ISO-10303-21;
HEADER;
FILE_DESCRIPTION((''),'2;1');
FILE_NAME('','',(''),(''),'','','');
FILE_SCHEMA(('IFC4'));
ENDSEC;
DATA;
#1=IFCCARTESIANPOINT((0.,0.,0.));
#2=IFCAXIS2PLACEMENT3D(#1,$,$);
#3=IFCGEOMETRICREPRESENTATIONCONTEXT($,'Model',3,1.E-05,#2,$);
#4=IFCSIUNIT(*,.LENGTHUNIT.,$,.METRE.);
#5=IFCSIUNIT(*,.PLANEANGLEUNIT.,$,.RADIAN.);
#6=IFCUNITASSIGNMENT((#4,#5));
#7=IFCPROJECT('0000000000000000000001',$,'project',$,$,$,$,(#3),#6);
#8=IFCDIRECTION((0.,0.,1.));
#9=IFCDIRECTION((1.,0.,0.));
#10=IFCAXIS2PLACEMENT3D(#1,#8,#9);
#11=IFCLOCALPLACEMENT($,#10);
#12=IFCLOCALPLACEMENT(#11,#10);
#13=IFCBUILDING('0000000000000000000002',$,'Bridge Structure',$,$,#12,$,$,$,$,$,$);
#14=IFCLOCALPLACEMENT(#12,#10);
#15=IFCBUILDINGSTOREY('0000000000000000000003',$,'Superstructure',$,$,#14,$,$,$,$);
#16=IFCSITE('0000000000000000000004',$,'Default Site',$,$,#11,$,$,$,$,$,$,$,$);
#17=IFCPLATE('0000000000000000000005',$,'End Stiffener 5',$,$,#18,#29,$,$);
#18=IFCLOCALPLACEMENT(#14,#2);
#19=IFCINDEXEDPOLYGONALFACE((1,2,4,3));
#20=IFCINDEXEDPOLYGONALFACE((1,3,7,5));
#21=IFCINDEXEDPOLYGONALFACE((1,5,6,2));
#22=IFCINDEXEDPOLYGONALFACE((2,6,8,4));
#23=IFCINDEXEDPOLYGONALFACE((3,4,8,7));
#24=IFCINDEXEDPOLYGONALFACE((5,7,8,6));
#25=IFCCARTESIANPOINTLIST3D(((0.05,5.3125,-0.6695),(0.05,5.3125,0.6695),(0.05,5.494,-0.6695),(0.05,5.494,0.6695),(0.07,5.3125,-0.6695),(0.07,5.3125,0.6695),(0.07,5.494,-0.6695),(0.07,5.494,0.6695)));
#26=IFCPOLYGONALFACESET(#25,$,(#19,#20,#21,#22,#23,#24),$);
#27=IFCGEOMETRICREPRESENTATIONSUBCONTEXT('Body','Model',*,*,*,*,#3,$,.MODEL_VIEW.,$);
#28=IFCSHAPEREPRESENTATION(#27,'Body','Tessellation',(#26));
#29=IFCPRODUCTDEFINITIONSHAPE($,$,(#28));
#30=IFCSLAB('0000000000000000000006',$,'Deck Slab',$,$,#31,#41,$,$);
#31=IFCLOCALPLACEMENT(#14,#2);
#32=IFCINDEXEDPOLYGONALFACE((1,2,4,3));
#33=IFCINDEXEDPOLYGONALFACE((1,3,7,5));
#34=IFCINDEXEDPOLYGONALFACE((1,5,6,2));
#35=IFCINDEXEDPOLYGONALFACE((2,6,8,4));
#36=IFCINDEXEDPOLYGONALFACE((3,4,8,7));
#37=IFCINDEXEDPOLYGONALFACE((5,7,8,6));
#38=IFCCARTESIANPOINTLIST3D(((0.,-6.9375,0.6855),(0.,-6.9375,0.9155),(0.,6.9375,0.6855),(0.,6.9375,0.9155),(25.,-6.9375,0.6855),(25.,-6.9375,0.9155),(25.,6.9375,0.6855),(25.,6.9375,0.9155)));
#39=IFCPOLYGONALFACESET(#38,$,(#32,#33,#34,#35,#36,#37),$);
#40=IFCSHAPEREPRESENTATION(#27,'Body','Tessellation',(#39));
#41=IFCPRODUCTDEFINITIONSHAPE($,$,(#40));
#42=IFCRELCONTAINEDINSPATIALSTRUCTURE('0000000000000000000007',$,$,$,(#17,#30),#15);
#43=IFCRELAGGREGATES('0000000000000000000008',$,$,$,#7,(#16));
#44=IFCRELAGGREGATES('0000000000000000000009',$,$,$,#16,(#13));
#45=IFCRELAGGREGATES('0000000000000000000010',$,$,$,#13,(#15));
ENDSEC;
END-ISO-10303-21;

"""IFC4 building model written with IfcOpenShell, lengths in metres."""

from ifc_helpers import new_model, si_unit, frame, origin, origin_with_axes, origin_2d_with_axis, place, context, subcontext, project, spatial, polyline, rectangle, outline, extrude, element, save


model = new_model("IFC4")

# Units and contexts
model_context = context("Model", 3, precision=1e-05, world=origin())
body_context = subcontext(model_context, "Body", "Model", "MODEL_VIEW")
ifc_project = project(units=[si_unit("LENGTHUNIT", "METRE"), si_unit("PLANEANGLEUNIT", "RADIAN")], contexts=[model_context])

# Site, building, storey
site_placement = place(None, origin_with_axes())
site = spatial("IfcSite", under=ifc_project, at=site_placement, Name="Default Site")
building_placement = place(site_placement, origin_with_axes())
building = spatial("IfcBuilding", under=site, at=building_placement, Name="Bridge Structure")
storey_placement = place(building_placement, origin_with_axes())
storey = spatial("IfcBuildingStorey", under=building, at=storey_placement, Name="Superstructure")

# Plate
for number, where, z_axis, x_axis, name in (
    (1, (0.06, 5.4032, -0.6695), (0.0, 0.0, 1.0), (1.0, 0.0, 0.0), "End Stiffener 5"),
):
    element("IfcPlate", number, at=place(storey_placement, frame(where, z_axis=z_axis, x_axis=x_axis)), inside=storey, Name=name, context=body_context, shape_type="SweptSolid", body=[
        extrude(rectangle(XDim=0.02, YDim=0.1815, at=origin_2d_with_axis()), origin_with_axes(), (0.0, 0.0, 1.0), 1.339),
    ])

# Slab
slab_placement = place(storey_placement, frame((0.0, 0.0, 0.6855), z_axis=(0.0, 0.0, 1.0), x_axis=(1.0, 0.0, 0.0)))
element("IfcSlab", 2, at=slab_placement, inside=storey, Name="Deck Slab", context=body_context, shape_type="SweptSolid", body=[
    extrude(outline(polyline([(0.0, -6.9375), (25.0, -6.9375), (25.0, 6.9375), (0.0, 6.9375), (0.0, -6.9375)])), origin_with_axes(), (0.0, 0.0, 1.0), 0.23),
])

save(model, "model.ifc")
